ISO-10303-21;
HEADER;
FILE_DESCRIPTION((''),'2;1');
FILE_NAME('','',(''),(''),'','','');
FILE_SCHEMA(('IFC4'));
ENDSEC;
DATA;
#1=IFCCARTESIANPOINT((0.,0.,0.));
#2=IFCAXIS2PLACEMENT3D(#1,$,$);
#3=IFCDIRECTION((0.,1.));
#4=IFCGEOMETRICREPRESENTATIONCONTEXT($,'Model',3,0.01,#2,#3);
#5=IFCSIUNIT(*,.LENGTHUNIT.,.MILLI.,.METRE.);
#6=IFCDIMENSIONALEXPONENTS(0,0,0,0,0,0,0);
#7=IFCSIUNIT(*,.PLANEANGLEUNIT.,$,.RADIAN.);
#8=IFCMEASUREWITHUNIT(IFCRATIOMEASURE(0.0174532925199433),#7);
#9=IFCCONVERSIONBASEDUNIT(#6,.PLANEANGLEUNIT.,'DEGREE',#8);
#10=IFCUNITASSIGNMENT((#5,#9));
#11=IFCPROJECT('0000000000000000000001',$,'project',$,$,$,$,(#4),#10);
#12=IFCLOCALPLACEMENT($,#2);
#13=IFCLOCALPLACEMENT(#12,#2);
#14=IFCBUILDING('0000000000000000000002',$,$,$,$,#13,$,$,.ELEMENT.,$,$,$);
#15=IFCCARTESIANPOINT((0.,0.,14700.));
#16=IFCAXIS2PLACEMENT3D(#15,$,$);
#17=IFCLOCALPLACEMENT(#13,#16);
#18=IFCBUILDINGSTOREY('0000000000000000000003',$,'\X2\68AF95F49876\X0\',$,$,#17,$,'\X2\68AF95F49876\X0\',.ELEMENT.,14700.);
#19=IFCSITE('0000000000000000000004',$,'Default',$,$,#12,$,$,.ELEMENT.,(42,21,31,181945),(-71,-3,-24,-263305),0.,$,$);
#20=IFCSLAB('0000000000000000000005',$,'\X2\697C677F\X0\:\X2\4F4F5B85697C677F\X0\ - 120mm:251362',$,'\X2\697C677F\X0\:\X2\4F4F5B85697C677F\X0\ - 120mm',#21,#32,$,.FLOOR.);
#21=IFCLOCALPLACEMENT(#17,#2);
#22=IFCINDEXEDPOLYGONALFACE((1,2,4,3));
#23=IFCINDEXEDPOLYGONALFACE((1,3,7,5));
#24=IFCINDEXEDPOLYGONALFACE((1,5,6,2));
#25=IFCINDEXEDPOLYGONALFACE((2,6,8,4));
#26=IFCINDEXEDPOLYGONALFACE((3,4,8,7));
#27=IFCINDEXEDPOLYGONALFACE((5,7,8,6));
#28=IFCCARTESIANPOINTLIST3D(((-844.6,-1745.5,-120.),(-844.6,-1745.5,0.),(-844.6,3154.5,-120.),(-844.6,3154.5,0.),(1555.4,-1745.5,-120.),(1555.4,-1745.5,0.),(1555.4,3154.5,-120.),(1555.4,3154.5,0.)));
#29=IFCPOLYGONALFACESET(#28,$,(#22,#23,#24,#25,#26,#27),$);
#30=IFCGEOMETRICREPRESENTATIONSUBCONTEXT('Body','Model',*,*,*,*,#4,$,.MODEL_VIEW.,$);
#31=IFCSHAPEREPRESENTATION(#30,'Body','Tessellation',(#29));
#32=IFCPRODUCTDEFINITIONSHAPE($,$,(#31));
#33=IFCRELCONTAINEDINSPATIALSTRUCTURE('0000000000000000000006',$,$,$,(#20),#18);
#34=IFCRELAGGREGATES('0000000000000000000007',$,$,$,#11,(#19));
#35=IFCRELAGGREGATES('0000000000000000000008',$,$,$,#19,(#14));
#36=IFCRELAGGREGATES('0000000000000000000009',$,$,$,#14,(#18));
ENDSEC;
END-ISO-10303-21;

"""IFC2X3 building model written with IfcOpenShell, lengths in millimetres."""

from ifc_helpers import new_model, entity, si_unit, converted_unit, direction, frame, origin, origin_2d_with_axis, place, context, subcontext, project, spatial, rectangle, extrude, element, save


model = new_model("IFC2X3")

# Units and contexts
model_context = context("Model", 3, precision=0.01, world=origin(), true_north=direction((0.0, 1.0)))
body_context = subcontext(model_context, "Body", "Model", "MODEL_VIEW")
ifc_project = project(units=[si_unit("LENGTHUNIT", "METRE", prefix="MILLI"), converted_unit("PLANEANGLEUNIT", "DEGREE", entity("IfcRatioMeasure", 0.0174532925199433), si_unit("PLANEANGLEUNIT", "RADIAN"), dimensions=[0, 0, 0, 0, 0, 0, 0])], contexts=[model_context])

# Site, building, storey
site_placement = place(None, origin())
site = spatial("IfcSite", under=ifc_project, at=site_placement, Name="Default", CompositionType="ELEMENT", RefLatitude=(42, 21, 31, 181945), RefLongitude=(-71, -3, -24, -263305), RefElevation=0.0)
building_placement = place(site_placement, origin())
building = spatial("IfcBuilding", under=site, at=building_placement, CompositionType="ELEMENT")
storey_placement = place(building_placement, frame((0.0, 0.0, 14700.0)))
storey = spatial("IfcBuildingStorey", under=building, at=storey_placement, Name="梯间顶", LongName="梯间顶", CompositionType="ELEMENT", Elevation=14700.0)

# Slab
slab_placement = place(storey_placement, origin())
element("IfcSlab", 1, at=slab_placement, inside=storey, Name="楼板:住宅楼板 - 120mm:251362", ObjectType="楼板:住宅楼板 - 120mm", PredefinedType="FLOOR", context=body_context, shape_type="SweptSolid", body=[
    extrude(rectangle(XDim=4900.0, YDim=2400.0, at=origin_2d_with_axis()), frame((355.4, 704.5, 0.0), z_axis=(0.0, 0.0, -1.0), x_axis=(0.0, 1.0, 0.0)), (0.0, 0.0, 1.0), 120.0),
])

save(model, "model.ifc")
